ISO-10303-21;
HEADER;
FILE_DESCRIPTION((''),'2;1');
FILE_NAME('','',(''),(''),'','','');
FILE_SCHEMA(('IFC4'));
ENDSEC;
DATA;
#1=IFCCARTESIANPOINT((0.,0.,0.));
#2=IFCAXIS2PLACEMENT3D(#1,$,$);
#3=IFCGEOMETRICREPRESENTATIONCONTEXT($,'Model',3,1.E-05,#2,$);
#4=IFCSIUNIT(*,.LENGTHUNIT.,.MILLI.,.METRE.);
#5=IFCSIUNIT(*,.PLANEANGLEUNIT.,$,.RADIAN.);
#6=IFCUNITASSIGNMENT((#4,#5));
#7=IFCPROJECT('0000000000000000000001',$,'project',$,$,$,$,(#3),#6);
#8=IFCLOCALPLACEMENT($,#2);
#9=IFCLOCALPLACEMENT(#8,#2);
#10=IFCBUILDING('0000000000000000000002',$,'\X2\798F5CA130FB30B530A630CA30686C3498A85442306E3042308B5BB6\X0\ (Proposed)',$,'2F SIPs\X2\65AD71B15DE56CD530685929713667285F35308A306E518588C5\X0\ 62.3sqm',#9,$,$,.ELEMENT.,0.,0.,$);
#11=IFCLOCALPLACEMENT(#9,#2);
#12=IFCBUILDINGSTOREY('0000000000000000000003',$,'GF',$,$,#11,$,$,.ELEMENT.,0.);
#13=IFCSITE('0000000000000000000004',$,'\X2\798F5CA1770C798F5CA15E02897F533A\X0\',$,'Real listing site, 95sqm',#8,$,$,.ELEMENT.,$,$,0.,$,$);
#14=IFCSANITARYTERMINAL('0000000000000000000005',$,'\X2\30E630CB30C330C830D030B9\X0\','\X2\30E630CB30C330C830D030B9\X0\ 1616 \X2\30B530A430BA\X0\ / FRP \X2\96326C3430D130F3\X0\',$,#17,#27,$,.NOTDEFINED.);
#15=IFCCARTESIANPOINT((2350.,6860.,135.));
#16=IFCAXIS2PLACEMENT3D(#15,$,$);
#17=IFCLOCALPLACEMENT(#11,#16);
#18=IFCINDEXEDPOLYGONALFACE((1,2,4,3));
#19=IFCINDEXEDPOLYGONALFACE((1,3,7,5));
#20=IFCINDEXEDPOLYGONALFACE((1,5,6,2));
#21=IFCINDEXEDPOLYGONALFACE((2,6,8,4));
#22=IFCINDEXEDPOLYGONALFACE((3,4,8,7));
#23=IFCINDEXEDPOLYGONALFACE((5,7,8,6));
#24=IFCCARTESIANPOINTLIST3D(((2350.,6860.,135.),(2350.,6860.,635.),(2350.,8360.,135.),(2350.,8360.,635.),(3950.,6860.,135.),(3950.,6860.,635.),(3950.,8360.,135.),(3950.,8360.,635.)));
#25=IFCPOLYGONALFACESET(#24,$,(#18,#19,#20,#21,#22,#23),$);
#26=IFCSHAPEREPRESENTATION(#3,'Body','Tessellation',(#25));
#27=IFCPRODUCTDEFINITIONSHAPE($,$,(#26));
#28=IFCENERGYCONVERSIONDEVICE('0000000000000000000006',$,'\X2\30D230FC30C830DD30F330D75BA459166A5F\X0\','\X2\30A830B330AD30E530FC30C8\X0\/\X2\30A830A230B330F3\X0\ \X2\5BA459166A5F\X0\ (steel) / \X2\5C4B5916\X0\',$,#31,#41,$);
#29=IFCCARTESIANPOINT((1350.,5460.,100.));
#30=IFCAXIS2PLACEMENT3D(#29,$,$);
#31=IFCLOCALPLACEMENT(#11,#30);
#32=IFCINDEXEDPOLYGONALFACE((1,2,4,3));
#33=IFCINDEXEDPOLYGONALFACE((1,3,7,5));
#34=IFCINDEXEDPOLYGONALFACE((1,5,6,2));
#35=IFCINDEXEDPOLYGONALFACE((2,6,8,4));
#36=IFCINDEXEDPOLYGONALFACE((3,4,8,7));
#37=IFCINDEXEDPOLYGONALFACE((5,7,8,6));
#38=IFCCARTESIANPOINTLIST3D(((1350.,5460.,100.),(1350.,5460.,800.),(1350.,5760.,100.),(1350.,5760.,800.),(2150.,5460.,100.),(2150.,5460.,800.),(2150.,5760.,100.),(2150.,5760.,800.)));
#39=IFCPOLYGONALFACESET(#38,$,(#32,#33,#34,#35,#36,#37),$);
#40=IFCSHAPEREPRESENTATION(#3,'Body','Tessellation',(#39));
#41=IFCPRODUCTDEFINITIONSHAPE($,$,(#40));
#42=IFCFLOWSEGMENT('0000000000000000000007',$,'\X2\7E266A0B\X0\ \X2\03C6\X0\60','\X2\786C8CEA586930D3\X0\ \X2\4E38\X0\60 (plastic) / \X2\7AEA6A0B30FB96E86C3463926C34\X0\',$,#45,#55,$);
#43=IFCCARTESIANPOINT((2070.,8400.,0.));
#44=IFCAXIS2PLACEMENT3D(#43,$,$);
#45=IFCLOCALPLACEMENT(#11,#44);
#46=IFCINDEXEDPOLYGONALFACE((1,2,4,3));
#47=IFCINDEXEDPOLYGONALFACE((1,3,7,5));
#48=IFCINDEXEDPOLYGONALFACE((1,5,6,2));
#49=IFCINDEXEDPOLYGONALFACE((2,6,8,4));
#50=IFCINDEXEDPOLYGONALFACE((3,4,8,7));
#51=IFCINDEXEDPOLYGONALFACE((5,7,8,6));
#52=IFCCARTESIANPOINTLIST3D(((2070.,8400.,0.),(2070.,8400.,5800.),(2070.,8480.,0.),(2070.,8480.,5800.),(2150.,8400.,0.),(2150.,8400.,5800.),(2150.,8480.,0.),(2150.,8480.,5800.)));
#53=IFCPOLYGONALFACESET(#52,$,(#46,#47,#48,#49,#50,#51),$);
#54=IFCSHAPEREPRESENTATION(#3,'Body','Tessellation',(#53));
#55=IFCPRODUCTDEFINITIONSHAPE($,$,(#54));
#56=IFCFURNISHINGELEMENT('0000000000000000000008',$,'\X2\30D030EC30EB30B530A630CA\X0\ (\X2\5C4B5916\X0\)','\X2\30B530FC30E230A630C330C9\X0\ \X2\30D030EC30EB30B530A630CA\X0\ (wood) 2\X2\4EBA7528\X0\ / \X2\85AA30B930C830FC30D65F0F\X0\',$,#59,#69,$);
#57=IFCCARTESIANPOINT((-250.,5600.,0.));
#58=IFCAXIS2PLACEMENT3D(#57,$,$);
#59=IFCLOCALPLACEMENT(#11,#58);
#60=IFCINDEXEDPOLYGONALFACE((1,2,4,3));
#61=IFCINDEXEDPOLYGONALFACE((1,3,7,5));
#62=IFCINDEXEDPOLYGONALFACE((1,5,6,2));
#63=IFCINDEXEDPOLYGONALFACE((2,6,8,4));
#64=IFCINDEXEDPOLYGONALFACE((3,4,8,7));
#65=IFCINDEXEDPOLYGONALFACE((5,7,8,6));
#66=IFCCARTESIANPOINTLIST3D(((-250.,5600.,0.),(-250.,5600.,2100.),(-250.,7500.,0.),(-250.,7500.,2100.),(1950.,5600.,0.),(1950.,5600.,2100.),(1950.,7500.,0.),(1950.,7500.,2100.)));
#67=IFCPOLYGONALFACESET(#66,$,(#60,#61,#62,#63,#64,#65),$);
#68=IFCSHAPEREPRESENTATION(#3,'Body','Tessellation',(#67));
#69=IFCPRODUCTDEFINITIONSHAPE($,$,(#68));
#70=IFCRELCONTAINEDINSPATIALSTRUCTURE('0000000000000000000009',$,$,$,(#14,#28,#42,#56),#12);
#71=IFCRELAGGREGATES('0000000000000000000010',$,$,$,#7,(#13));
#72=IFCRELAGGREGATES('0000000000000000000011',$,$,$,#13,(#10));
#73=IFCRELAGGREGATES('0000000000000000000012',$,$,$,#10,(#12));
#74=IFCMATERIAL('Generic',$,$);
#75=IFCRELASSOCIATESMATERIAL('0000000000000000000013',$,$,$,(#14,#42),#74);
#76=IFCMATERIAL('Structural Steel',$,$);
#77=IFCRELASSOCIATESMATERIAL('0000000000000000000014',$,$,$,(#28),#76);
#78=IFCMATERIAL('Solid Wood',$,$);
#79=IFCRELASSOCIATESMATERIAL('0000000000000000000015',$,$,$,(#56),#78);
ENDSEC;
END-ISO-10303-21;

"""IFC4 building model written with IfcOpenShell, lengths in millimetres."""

from ifc_helpers import new_model, si_unit, frame, frame_2d, origin, place, context, project, spatial, rectangle, extrude, material, element, save


model = new_model("IFC4")

# Units and contexts
model_context = context("Model", 3, precision=1e-05, world=origin())
ifc_project = project(units=[si_unit("LENGTHUNIT", "METRE", prefix="MILLI"), si_unit("PLANEANGLEUNIT", "RADIAN")], contexts=[model_context])

# Site, building, storey
site_placement = place(None, origin())
site = spatial("IfcSite", under=ifc_project, at=site_placement, Name="福岡県福岡市西区", ObjectType="Real listing site, 95sqm", CompositionType="ELEMENT", RefElevation=0.0)
building_placement = place(site_placement, origin())
building = spatial("IfcBuilding", under=site, at=building_placement, Name="福岡・サウナと水風呂のある家 (Proposed)", ObjectType="2F SIPs断熱工法と天然木張りの内装 62.3sqm", CompositionType="ELEMENT", ElevationOfRefHeight=0.0, ElevationOfTerrain=0.0)
storey_placement = place(building_placement, origin())
storey = spatial("IfcBuildingStorey", under=building, at=storey_placement, Name="GF", CompositionType="ELEMENT", Elevation=0.0)

# Shared definitions
ifc_material_1 = material(Name="Solid Wood")

# Shared definitions
ifc_material_2 = material(Name="Generic")

# Sanitary terminal
sanitary_terminal_placement = place(storey_placement, frame((2350.0, 6860.0, 135.0)))
element("IfcSanitaryTerminal", 1, at=sanitary_terminal_placement, inside=storey, material=ifc_material_2, Name="ユニットバス", Description="ユニットバス 1616 サイズ / FRP 防水パン", PredefinedType="NOTDEFINED", context=model_context, shape_type="SweptSolid", body=[
    extrude(rectangle(XDim=1600.0, YDim=1500.0, at=frame_2d((800.0, 750.0))), frame((2350.0, 6860.0, 135.0)), (0.0, 0.0, 1.0), 500.0),
])

# Energy conversion device
ifc_material_3 = material(Name="Structural Steel")
energy_conversion_device_placement = place(storey_placement, frame((1350.0, 5460.0, 100.0)))
element("IfcEnergyConversionDevice", 2, at=energy_conversion_device_placement, inside=storey, material=ifc_material_3, Name="ヒートポンプ室外機", Description="エコキュート/エアコン 室外機 (steel) / 屋外", context=model_context, shape_type="SweptSolid", body=[
    extrude(rectangle(XDim=800.0, YDim=300.0, at=frame_2d((400.0, 150.0))), frame((1350.0, 5460.0, 100.0)), (0.0, 0.0, 1.0), 700.0),
])

# Flow segment
flow_segment_placement = place(storey_placement, frame((2070.0, 8400.0, 0.0)))
element("IfcFlowSegment", 3, at=flow_segment_placement, inside=storey, material=ifc_material_2, Name="縦樋 φ60", Description="硬質塩ビ 丸60 (plastic) / 竪樋・雨水排水", context=model_context, shape_type="SweptSolid", body=[
    extrude(rectangle(XDim=80.0, YDim=80.0, at=frame_2d((40.0, 40.0))), frame((2070.0, 8400.0, 0.0)), (0.0, 0.0, 1.0), 5800.0),
])

# Furnishing element
furnishing_placement = place(storey_placement, frame((-250.0, 5600.0, 0.0)))
element("IfcFurnishingElement", 4, at=furnishing_placement, inside=storey, material=ifc_material_1, Name="バレルサウナ (屋外)", Description="サーモウッド バレルサウナ (wood) 2人用 / 薪ストーブ式", context=model_context, shape_type="SweptSolid", body=[
    extrude(rectangle(XDim=2200.0, YDim=1900.0, at=frame_2d((1100.0, 950.0))), frame((-250.0, 5600.0, 0.0)), (0.0, 0.0, 1.0), 2100.0),
])

save(model, "model.ifc")
